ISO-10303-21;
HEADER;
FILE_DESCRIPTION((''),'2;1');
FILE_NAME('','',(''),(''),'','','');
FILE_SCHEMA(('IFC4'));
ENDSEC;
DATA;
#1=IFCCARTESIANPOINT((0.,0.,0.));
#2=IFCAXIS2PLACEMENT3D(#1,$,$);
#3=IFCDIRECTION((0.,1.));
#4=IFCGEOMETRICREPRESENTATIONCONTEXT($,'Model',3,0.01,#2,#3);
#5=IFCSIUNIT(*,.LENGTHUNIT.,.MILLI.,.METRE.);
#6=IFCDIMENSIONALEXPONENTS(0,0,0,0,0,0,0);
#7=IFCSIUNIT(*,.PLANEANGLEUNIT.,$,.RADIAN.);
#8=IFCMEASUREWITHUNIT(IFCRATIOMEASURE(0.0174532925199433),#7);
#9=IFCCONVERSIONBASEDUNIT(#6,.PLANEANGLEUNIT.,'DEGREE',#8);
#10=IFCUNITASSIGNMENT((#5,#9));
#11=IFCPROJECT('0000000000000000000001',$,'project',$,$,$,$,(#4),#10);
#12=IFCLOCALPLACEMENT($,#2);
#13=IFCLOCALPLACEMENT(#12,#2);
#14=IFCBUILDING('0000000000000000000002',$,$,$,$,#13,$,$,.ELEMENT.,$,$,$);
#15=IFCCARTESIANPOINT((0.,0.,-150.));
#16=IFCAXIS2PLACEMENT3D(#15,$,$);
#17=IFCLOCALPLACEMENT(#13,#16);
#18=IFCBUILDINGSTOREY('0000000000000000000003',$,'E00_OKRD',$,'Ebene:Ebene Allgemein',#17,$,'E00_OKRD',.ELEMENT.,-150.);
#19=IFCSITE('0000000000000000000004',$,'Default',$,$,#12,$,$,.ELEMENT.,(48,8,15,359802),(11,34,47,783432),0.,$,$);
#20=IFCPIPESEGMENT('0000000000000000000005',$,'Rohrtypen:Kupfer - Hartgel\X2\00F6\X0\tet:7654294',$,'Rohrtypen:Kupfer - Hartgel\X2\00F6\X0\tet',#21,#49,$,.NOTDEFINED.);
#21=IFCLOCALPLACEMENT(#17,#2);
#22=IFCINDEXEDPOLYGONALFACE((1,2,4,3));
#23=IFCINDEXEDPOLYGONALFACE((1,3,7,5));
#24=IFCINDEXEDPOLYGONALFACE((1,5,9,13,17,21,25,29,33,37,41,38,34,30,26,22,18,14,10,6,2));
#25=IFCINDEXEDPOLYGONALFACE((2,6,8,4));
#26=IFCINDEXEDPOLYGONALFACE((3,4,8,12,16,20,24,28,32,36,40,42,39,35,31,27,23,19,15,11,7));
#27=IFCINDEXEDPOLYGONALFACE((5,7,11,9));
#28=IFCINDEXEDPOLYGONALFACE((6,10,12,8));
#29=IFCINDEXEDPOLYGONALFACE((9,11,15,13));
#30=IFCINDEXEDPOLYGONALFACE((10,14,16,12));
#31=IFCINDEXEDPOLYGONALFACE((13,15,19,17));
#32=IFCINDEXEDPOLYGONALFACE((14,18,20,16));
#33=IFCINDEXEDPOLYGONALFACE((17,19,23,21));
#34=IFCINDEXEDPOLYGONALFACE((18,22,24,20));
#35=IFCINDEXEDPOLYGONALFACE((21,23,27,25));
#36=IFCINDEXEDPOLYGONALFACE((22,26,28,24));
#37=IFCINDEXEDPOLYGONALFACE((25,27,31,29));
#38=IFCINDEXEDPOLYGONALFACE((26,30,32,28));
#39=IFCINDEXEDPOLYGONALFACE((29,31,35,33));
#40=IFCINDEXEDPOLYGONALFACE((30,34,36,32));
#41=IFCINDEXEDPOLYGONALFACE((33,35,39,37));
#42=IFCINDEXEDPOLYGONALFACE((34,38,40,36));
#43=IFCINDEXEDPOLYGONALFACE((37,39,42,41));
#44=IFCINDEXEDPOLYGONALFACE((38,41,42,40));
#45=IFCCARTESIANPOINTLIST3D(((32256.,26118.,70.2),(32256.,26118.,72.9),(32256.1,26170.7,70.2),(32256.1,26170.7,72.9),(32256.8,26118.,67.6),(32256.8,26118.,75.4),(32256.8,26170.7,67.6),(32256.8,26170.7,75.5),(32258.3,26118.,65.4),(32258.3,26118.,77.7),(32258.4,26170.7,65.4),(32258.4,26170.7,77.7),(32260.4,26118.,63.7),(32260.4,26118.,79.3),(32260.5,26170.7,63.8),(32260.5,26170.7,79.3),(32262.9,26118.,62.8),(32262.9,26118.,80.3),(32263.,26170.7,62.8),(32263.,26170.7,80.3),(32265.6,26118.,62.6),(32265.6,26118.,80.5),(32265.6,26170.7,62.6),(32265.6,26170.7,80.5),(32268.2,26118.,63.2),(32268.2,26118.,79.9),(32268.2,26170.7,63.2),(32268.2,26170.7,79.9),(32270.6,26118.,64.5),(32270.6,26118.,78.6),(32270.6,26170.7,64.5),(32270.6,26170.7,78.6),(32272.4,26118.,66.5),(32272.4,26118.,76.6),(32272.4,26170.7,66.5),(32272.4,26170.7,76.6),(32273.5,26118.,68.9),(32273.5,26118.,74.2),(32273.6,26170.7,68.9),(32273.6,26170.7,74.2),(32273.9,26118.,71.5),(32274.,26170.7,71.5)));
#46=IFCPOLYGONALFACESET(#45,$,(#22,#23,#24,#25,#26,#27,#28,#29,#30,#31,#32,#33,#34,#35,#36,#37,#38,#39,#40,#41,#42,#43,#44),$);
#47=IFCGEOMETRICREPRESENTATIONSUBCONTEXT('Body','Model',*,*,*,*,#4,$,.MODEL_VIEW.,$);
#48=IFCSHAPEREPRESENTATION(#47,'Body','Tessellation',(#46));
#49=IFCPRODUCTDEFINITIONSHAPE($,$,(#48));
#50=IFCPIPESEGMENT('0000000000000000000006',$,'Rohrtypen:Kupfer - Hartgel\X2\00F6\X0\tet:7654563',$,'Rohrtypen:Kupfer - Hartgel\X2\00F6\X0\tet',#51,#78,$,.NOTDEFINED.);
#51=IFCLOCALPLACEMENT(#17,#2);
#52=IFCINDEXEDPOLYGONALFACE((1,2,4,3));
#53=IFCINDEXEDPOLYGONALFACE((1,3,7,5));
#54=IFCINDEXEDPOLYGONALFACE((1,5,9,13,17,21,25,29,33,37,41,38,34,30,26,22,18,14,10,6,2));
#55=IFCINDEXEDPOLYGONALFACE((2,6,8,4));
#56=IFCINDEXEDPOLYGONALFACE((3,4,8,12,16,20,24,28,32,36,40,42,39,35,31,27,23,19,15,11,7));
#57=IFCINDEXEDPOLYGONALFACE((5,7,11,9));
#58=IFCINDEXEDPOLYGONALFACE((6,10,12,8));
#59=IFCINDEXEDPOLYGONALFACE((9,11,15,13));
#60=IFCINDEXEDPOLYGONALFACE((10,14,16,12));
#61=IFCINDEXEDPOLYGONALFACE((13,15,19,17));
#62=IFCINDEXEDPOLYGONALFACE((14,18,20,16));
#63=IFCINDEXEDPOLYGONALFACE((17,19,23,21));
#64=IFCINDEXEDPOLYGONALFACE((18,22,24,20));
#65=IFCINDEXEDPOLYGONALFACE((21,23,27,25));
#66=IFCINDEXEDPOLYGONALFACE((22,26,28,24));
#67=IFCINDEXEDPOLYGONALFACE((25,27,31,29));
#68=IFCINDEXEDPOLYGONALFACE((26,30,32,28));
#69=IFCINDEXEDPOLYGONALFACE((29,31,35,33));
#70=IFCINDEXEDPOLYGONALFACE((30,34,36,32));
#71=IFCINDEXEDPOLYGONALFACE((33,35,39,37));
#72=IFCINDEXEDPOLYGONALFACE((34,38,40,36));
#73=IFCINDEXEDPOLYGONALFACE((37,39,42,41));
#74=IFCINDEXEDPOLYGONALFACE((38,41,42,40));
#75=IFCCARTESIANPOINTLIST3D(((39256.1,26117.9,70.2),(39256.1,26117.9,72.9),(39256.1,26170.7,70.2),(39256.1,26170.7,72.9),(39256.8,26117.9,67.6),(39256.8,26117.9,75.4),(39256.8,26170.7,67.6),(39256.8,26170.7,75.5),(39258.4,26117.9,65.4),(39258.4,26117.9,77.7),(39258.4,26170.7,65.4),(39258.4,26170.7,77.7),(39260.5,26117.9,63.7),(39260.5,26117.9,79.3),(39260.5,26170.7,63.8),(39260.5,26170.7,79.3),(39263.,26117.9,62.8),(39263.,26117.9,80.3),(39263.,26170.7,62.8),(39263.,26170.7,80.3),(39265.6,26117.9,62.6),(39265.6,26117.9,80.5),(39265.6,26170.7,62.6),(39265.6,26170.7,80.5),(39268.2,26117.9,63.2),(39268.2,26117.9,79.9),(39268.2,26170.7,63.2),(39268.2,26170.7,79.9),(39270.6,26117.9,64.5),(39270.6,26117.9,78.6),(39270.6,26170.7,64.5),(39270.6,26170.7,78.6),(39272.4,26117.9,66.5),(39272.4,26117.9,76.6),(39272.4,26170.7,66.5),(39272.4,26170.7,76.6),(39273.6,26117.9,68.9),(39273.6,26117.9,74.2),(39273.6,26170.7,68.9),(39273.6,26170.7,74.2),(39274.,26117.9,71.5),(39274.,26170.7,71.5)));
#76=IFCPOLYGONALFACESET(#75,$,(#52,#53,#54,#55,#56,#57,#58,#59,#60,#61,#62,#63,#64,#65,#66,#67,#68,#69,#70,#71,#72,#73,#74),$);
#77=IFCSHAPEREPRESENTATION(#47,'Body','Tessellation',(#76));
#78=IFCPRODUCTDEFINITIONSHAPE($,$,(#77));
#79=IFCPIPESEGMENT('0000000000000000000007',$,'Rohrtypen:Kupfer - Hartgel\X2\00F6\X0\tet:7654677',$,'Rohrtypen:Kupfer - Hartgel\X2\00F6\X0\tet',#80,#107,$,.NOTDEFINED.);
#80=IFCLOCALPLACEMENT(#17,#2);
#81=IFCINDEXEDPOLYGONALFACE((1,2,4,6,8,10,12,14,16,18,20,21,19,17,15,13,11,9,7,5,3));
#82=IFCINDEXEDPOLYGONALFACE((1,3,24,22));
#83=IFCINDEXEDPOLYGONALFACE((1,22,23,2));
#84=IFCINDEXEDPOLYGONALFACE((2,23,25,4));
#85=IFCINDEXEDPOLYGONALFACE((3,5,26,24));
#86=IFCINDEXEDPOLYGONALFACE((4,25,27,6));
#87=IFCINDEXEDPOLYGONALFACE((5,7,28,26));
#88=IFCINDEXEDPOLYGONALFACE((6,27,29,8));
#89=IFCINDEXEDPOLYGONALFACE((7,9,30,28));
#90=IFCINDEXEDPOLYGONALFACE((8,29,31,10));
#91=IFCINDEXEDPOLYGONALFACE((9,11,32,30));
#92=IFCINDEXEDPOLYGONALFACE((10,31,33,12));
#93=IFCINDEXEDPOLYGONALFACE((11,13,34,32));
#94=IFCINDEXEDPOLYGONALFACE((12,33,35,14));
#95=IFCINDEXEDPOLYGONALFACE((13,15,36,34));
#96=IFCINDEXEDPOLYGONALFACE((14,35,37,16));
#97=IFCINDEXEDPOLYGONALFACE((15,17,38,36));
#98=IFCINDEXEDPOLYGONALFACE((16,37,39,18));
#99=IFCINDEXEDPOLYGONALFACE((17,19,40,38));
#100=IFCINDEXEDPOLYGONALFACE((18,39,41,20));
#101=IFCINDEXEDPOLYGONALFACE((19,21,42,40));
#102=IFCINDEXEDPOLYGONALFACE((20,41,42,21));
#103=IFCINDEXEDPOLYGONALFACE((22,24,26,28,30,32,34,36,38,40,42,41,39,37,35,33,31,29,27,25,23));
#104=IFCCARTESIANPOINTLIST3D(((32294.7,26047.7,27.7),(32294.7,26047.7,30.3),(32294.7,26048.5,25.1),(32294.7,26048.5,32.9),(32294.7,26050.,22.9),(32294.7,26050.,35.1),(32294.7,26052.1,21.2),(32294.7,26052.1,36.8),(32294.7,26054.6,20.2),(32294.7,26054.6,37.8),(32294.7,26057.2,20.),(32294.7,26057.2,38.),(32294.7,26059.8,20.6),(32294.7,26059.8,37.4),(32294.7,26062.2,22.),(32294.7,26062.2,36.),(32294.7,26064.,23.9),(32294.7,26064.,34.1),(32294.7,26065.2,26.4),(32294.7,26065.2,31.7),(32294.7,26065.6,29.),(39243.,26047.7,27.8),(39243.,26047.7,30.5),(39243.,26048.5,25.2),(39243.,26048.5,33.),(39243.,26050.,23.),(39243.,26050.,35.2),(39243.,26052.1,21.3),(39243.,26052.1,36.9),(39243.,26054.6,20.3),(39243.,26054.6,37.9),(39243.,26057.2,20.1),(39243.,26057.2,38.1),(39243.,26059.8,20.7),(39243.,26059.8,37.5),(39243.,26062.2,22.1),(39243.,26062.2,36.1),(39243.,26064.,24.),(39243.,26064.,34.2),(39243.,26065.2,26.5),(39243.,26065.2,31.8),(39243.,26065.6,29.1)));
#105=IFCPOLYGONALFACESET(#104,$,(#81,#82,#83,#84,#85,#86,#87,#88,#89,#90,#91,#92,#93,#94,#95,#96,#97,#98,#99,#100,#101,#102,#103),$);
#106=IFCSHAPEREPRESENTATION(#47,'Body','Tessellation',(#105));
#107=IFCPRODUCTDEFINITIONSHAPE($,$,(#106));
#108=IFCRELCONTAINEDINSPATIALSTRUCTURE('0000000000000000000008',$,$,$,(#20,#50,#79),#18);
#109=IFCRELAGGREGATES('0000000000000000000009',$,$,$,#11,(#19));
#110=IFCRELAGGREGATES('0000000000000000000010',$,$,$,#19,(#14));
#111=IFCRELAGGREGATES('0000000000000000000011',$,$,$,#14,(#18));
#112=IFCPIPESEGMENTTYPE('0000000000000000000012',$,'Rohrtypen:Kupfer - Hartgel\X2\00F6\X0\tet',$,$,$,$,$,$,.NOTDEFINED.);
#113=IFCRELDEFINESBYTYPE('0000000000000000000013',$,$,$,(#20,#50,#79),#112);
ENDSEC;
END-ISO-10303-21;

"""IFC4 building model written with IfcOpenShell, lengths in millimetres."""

from ifc_helpers import new_model, entity, si_unit, converted_unit, direction, frame, frame_2d, origin, origin_2d_with_axis, place, context, subcontext, project, spatial, circle, extrude, type_object, element, save


model = new_model("IFC4")

# Units and contexts
model_context = context("Model", 3, precision=0.01, world=origin(), true_north=direction((0.0, 1.0)))
body_context = subcontext(model_context, "Body", "Model", "MODEL_VIEW")
ifc_project = project(units=[si_unit("LENGTHUNIT", "METRE", prefix="MILLI"), converted_unit("PLANEANGLEUNIT", "DEGREE", entity("IfcRatioMeasure", 0.0174532925199433), si_unit("PLANEANGLEUNIT", "RADIAN"), dimensions=[0, 0, 0, 0, 0, 0, 0])], contexts=[model_context])

# Site, building, storey
site_placement = place(None, origin())
site = spatial("IfcSite", under=ifc_project, at=site_placement, Name="Default", CompositionType="ELEMENT", RefLatitude=(48, 8, 15, 359802), RefLongitude=(11, 34, 47, 783432), RefElevation=0.0)
building_placement = place(site_placement, origin())
building = spatial("IfcBuilding", under=site, at=building_placement, CompositionType="ELEMENT")
storey_placement = place(building_placement, frame((0.0, 0.0, -150.0)))
storey = spatial("IfcBuildingStorey", under=building, at=storey_placement, Name="E00_OKRD", ObjectType="Ebene:Ebene Allgemein", LongName="E00_OKRD", CompositionType="ELEMENT", Elevation=-150.0)

# Pipe segments
pipe_segment_type = type_object("IfcPipeSegmentType", Name="Rohrtypen:Kupfer - Hartgelötet", PredefinedType="NOTDEFINED")
pipe_segment_1_placement = place(storey_placement, frame((32254.3, 26118.0, 60.9)))
element("IfcPipeSegment", 1, at=pipe_segment_1_placement, inside=storey, type_object=pipe_segment_type, Name="Rohrtypen:Kupfer - Hartgelötet:7654294", ObjectType="Rohrtypen:Kupfer - Hartgelötet", PredefinedType="NOTDEFINED", context=body_context, shape_type="SweptSolid", body=[
    extrude(circle(Radius=9.0, at=origin_2d_with_axis()), frame((10.6, 0.0, 10.6), z_axis=(0.00019, 1.0, 0.000295), x_axis=(1.0, -0.00019, 0.0)), (0.0, 0.0, 1.0), 52.6),
])
pipe_segment_2_placement = place(storey_placement, frame((39254.4, 26117.9, 60.9)))
element("IfcPipeSegment", 2, at=pipe_segment_2_placement, inside=storey, type_object=pipe_segment_type, Name="Rohrtypen:Kupfer - Hartgelötet:7654563", ObjectType="Rohrtypen:Kupfer - Hartgelötet", PredefinedType="NOTDEFINED", context=body_context, shape_type="SweptSolid", body=[
    extrude(circle(Radius=9.0, at=origin_2d_with_axis()), frame((10.6, 0.0, 10.6), z_axis=(-0.000028, 1.0, 0.000282), x_axis=(1.0, 0.000028, 0.0)), (0.0, 0.0, 1.0), 52.7),
])
pipe_segment_3_placement = place(storey_placement, frame((32294.7, 26046.0, 18.4)))
element("IfcPipeSegment", 3, at=pipe_segment_3_placement, inside=storey, type_object=pipe_segment_type, Name="Rohrtypen:Kupfer - Hartgelötet:7654677", ObjectType="Rohrtypen:Kupfer - Hartgelötet", PredefinedType="NOTDEFINED", context=body_context, shape_type="SweptSolid", body=[
    extrude(circle(Radius=9.0, at=frame_2d((0.0, 0.0), x_axis=(1.0, 0.0))), frame((0.0, 10.6, 10.6), z_axis=(1.0, 0.0, 0.000015), x_axis=(0.0, 1.0, 0.0)), (0.0, 0.0, 1.0), 6948.2),
])

save(model, "model.ifc")
